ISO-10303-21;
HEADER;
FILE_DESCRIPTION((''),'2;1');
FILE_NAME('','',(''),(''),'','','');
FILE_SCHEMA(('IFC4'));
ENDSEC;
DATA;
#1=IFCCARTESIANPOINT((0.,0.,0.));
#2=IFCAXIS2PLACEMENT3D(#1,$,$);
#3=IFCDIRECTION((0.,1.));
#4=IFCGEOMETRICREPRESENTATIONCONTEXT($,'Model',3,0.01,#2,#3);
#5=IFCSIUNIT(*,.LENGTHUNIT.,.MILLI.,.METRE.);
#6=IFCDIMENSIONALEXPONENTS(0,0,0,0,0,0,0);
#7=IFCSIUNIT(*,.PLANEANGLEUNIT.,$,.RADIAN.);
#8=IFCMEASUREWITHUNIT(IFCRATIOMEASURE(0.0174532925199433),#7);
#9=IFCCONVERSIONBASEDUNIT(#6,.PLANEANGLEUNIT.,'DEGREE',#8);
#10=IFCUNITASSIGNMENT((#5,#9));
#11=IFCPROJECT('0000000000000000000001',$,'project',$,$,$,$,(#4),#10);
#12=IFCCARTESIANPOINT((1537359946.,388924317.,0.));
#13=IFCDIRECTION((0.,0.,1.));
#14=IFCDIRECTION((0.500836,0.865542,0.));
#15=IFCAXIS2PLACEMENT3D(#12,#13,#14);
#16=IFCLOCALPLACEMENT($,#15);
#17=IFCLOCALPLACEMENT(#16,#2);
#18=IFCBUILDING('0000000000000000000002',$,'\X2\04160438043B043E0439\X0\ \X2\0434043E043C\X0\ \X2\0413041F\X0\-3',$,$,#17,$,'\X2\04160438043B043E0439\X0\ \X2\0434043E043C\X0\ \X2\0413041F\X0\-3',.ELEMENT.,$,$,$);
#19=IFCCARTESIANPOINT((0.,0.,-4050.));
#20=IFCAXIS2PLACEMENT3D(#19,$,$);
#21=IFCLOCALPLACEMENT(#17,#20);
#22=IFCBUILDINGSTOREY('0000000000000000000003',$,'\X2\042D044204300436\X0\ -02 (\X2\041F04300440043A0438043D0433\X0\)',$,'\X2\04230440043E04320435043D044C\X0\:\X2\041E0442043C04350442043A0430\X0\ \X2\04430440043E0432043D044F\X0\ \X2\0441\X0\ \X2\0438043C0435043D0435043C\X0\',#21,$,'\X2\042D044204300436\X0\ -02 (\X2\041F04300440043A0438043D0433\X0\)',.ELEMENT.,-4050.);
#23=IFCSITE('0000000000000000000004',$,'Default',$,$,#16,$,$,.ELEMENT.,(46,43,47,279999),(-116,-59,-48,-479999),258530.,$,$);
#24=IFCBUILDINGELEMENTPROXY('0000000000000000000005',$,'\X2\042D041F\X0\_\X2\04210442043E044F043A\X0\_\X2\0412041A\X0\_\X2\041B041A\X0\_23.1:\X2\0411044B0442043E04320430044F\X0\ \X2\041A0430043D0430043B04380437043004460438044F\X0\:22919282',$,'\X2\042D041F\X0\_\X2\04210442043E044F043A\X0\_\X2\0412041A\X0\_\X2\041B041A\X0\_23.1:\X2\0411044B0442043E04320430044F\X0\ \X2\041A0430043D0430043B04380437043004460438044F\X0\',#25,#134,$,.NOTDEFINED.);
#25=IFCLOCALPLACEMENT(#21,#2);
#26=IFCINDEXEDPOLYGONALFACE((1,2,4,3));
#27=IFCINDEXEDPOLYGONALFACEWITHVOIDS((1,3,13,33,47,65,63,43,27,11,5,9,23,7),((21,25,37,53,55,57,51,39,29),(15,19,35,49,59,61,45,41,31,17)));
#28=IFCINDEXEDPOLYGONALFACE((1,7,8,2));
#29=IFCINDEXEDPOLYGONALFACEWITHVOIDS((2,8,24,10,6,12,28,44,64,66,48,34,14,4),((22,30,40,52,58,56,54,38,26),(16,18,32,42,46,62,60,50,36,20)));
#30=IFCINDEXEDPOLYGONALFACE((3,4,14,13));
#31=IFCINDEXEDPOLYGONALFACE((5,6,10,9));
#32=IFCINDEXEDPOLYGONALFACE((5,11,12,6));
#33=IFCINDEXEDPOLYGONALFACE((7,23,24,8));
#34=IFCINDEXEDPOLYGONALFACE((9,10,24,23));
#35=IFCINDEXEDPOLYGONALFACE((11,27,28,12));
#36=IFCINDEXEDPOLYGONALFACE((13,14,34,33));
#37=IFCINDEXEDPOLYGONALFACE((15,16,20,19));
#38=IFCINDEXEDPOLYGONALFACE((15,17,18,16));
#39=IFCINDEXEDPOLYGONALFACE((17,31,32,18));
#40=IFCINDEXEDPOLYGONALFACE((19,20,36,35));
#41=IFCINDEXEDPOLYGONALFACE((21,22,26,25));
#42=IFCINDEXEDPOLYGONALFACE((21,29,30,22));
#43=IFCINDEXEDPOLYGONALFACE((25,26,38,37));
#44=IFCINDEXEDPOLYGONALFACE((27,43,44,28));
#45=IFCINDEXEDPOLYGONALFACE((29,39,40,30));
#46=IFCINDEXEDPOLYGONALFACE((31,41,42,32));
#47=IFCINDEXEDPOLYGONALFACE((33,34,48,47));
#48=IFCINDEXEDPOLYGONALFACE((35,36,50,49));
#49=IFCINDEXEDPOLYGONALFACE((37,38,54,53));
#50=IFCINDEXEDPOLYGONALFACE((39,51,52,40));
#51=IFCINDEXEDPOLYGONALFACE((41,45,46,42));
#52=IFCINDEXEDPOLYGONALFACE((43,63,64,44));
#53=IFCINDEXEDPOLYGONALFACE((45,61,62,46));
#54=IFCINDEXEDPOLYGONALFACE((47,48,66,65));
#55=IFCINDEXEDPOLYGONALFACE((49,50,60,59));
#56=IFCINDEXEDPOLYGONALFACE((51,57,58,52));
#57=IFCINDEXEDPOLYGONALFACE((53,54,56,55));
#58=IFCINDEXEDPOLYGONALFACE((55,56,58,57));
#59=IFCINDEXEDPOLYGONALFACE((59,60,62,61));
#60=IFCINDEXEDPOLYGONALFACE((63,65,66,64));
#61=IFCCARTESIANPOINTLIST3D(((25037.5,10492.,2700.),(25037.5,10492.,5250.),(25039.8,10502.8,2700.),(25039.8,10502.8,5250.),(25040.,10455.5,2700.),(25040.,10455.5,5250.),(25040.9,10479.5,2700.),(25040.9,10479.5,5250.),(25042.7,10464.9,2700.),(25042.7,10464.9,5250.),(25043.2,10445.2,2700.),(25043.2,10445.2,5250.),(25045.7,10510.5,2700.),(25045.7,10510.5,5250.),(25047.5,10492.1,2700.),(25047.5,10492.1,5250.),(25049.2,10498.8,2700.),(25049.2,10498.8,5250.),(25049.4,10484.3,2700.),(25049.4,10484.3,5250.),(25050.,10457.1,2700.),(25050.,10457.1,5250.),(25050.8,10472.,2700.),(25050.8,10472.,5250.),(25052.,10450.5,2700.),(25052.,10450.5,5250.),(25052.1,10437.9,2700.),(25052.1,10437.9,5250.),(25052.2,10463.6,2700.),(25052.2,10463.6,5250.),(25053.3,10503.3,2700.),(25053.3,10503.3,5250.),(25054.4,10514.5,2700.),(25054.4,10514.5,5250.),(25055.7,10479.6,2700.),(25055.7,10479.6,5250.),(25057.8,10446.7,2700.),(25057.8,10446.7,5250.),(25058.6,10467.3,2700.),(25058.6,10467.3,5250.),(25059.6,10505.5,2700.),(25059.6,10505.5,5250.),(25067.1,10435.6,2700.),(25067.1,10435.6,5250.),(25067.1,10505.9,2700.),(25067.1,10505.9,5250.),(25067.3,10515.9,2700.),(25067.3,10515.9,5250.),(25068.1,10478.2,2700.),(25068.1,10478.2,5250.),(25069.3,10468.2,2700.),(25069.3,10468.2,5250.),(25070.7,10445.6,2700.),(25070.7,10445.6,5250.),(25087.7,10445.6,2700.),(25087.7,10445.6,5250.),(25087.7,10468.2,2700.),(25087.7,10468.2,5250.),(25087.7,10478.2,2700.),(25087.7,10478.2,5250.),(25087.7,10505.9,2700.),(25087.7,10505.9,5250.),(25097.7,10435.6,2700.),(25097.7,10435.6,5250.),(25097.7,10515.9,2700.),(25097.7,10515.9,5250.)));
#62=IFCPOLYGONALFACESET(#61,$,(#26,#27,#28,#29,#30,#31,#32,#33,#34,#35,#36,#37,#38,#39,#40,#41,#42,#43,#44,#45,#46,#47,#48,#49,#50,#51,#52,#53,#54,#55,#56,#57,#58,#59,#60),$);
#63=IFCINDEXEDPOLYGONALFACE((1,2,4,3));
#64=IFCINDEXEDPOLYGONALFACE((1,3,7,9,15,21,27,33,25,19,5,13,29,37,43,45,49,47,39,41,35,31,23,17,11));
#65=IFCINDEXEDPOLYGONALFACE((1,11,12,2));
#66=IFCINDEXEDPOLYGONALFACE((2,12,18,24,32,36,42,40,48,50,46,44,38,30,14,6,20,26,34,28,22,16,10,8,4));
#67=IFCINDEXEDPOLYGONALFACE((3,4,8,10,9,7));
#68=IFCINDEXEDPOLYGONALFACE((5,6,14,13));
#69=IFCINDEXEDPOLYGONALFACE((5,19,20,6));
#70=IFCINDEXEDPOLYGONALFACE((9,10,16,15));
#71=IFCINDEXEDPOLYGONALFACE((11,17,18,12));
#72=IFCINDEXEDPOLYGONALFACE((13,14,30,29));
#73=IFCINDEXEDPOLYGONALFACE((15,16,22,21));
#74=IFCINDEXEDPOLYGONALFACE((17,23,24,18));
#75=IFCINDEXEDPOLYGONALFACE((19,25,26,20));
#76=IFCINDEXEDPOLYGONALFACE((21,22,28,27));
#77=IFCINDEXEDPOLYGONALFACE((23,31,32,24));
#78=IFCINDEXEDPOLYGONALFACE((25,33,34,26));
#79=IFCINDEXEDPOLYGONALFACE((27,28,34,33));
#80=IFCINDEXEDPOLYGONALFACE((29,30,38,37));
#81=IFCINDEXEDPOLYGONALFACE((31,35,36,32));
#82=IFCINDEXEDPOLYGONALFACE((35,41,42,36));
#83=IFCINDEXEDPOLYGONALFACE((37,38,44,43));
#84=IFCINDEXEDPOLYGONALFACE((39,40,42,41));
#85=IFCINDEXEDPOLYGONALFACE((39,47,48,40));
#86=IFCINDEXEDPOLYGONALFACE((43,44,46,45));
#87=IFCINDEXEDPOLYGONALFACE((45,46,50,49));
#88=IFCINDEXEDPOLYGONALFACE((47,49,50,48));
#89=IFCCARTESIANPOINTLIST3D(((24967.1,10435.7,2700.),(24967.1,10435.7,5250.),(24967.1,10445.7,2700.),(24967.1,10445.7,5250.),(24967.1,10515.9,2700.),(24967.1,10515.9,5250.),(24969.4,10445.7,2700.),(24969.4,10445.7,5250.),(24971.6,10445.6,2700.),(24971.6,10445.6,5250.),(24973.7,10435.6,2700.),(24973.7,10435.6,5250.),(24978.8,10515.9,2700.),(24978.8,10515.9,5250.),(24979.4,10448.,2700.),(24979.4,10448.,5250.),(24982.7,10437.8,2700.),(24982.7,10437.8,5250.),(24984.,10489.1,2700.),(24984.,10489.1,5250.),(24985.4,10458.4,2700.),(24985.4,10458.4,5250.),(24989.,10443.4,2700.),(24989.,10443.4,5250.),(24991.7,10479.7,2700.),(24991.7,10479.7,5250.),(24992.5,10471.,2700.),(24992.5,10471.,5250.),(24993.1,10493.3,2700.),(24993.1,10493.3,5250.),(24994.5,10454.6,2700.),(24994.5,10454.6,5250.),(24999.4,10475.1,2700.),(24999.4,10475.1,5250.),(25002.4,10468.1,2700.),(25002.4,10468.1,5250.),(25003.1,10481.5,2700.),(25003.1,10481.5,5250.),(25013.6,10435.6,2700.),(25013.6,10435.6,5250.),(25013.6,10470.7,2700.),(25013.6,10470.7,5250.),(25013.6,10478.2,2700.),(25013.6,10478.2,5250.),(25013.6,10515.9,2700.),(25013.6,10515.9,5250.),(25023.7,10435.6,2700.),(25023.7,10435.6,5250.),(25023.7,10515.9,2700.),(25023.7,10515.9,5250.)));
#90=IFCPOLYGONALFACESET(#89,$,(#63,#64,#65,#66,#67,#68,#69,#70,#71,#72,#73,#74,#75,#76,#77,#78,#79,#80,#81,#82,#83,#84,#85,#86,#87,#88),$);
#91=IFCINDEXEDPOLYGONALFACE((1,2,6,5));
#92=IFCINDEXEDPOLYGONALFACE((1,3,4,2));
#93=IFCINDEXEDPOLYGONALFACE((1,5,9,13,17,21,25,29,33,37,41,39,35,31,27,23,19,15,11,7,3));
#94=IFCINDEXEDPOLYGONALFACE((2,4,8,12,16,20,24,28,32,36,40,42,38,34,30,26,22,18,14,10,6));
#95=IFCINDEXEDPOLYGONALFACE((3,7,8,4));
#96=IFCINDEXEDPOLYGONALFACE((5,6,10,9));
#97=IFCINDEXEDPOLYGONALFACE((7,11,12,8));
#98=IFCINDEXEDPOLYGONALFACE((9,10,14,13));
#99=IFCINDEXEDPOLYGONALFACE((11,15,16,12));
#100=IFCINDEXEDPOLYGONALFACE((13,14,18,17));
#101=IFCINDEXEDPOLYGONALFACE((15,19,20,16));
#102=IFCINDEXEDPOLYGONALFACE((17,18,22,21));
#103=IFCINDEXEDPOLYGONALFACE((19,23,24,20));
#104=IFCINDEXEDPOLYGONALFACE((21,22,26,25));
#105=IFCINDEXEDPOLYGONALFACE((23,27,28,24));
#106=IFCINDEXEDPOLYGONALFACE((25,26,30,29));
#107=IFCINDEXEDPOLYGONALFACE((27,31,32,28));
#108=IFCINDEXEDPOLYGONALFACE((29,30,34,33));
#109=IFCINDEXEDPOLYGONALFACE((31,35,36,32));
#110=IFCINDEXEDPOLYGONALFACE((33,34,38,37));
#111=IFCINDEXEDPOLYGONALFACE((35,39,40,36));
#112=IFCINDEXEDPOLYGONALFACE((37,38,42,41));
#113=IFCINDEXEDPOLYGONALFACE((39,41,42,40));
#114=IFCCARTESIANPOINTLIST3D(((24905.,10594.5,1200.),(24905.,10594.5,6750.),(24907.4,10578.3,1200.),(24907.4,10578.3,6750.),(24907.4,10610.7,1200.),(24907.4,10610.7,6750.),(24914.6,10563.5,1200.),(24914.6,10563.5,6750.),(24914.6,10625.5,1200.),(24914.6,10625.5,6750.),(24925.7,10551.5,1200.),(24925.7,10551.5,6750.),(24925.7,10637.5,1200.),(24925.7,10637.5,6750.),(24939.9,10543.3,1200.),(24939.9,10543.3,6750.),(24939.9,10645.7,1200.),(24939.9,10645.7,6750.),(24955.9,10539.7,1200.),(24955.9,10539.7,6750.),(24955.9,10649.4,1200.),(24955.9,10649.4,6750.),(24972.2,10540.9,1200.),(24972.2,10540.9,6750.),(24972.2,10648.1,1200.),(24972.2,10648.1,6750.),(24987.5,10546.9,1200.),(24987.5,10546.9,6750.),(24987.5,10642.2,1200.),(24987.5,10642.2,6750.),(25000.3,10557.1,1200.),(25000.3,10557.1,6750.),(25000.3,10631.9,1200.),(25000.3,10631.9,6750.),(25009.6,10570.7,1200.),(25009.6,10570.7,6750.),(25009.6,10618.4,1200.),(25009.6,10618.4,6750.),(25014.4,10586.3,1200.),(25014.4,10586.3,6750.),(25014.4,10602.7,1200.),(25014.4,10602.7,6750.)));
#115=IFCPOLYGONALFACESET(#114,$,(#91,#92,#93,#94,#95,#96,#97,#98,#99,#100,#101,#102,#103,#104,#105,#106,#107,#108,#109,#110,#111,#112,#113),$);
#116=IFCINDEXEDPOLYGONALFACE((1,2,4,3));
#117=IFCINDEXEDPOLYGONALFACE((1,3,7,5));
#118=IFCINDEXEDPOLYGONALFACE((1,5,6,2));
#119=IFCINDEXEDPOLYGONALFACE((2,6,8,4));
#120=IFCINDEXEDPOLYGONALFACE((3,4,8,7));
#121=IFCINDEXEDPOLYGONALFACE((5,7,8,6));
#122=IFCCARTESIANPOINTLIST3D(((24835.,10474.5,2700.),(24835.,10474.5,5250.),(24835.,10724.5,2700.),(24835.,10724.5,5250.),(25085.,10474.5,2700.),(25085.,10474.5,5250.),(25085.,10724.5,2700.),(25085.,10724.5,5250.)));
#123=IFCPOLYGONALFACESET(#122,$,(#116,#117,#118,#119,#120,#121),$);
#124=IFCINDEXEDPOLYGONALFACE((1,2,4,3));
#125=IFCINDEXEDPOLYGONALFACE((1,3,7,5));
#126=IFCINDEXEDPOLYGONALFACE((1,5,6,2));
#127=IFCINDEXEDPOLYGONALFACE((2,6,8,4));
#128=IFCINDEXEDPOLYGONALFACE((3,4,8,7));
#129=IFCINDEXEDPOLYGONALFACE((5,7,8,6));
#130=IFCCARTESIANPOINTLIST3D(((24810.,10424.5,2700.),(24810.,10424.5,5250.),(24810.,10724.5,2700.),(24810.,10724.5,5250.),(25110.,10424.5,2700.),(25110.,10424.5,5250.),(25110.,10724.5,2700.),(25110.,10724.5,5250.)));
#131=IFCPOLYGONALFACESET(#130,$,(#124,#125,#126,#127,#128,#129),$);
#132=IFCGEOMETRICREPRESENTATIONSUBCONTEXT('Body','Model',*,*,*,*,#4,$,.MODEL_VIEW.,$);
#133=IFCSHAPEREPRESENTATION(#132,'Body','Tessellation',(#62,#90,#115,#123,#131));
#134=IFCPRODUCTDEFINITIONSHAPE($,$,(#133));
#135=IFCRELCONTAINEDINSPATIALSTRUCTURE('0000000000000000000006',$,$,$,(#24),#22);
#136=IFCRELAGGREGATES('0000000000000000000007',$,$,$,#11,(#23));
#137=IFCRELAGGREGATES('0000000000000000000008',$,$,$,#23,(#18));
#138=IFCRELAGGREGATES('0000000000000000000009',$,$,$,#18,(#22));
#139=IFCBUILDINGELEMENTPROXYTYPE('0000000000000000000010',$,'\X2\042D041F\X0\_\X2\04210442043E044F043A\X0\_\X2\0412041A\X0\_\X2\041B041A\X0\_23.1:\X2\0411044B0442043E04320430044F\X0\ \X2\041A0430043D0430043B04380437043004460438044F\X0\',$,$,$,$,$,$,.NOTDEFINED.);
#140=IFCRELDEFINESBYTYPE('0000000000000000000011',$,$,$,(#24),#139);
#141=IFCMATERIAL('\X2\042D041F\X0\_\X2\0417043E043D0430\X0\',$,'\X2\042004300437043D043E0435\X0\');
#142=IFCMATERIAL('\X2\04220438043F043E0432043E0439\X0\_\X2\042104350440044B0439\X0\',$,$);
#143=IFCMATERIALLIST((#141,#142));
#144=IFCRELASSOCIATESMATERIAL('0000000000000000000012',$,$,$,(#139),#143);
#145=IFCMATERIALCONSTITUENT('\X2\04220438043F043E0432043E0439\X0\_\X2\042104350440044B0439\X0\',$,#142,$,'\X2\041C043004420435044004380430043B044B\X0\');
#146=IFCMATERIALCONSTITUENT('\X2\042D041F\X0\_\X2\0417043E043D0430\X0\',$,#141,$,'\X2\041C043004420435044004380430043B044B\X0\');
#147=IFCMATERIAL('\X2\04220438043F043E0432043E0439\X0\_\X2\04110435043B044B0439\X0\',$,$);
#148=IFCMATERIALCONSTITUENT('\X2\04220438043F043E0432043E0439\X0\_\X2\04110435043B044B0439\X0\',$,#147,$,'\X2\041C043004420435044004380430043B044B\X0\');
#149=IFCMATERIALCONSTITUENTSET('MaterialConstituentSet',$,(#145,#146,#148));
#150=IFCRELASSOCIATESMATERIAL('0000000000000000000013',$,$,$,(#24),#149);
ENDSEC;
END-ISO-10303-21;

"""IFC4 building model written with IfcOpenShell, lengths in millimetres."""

from ifc_helpers import new_model, entity, si_unit, converted_unit, direction, frame, frame_2d, origin, place, context, subcontext, project, spatial, polyline, rectangle, circle, outline, extrude, source, transform, mapped, material, material_list, constituent, constituent_set, type_object, type_shapes, element, save


model = new_model("IFC4")

# Units and contexts
model_context = context("Model", 3, precision=0.01, world=origin(), true_north=direction((0.0, 1.0)))
body_context = subcontext(model_context, "Body", "Model", "MODEL_VIEW")
ifc_project = project(units=[si_unit("LENGTHUNIT", "METRE", prefix="MILLI"), converted_unit("PLANEANGLEUNIT", "DEGREE", entity("IfcRatioMeasure", 0.0174532925199433), si_unit("PLANEANGLEUNIT", "RADIAN"), dimensions=[0, 0, 0, 0, 0, 0, 0])], contexts=[model_context])

# Site, building, storey
site_placement = place(None, frame((1537359946.0, 388924317.0, 0.0), z_axis=(0.0, 0.0, 1.0), x_axis=(0.500836, 0.865542, 0.0)))
site = spatial("IfcSite", under=ifc_project, at=site_placement, Name="Default", CompositionType="ELEMENT", RefLatitude=(46, 43, 47, 279999), RefLongitude=(-116, -59, -48, -479999), RefElevation=258530.0)
building_placement = place(site_placement, origin())
building = spatial("IfcBuilding", under=site, at=building_placement, Name="Жилой дом ГП-3", LongName="Жилой дом ГП-3", CompositionType="ELEMENT")
storey_placement = place(building_placement, frame((0.0, 0.0, -4050.0)))
storey = spatial("IfcBuildingStorey", under=building, at=storey_placement, Name="Этаж -02 (Паркинг)", ObjectType="Уровень:Отметка уровня с именем", LongName="Этаж -02 (Паркинг)", CompositionType="ELEMENT", Elevation=-4050.0)

# Shared definitions
ifc_material_1 = material(Name="ЭП_Зона", Category="Разное")
ifc_material_2 = material(Name="Типовой_Белый")
ifc_material_3 = material(Name="Типовой_Серый")

# Building element proxy
ifc_material_list_1 = material_list([ifc_material_1, ifc_material_3])
building_element_proxy_type_1 = type_object("IfcBuildingElementProxyType", Name="ЭП_Стояк_ВК_ЛК_23.1:Бытовая Канализация", PredefinedType="NOTDEFINED", material=ifc_material_list_1)
shared_shape_1 = source(origin(), body_context, "Body", "SweptSolid", [
    extrude(outline(polyline([(-42.2, -39.0), (-11.8, -39.0), (1.1, -37.6), (9.8, -33.5), (15.7, -25.8), (18.0, -15.0), (14.6, -2.5), (4.7, 5.0), (12.8, 12.1), (15.5, 21.5), (12.3, 31.8), (3.4, 39.0), (-11.6, 41.4), (-42.2, 41.4), (-42.2, -39.0)]), holes=[polyline([(-32.2, 8.8), (-32.2, 31.4), (-15.2, 31.4), (-2.3, 30.3), (3.5, 26.4), (5.5, 19.9), (3.3, 13.3), (-3.1, 9.6), (-13.9, 8.8), (-32.2, 8.8)]), polyline([(-32.2, -28.9), (-32.2, -1.3), (-12.6, -1.3), (-0.2, -2.6), (6.1, -7.3), (8.0, -15.1), (6.3, -21.9), (2.2, -26.3), (-4.1, -28.5), (-11.6, -28.9), (-32.2, -28.9)])]), frame((54.5, -52.4, -1350.0)), (0.0, 0.0, 1.0), 2550.0),
    extrude(outline(polyline([(-32.1, -31.9), (48.3, -31.9), (48.3, -21.8), (10.6, -21.8), (13.8, -11.4), (25.6, -1.3), (48.3, 13.0), (48.3, 24.6), (21.4, 7.7), (12.0, 0.1), (7.4, -7.7), (3.3, -0.7), (-9.3, 6.4), (-19.7, 12.3), (-22.1, 20.2), (-22.0, 22.4), (-22.0, 24.6), (-32.0, 24.6), (-32.1, 18.0), (-29.9, 9.0), (-24.3, 2.8), (-13.1, -2.8), (0.4, -10.6), (3.0, -21.8), (-32.1, -21.8), (-32.1, -31.9)])), frame((118.2, -43.1, -1350.0), z_axis=(0.0, 0.0, 1.0), x_axis=(0.0, -1.0, 0.0)), (0.0, 0.0, 1.0), 2550.0),
    extrude(circle(Radius=55.0, at=frame_2d((0.0, 0.0), x_axis=(1.0, 0.0))), frame((150.0, -170.0, -2850.0)), (0.0, 0.0, 1.0), 5550.0),
    extrude(rectangle(XDim=250.0, YDim=250.0, at=frame_2d((0.0, 0.0), x_axis=(1.0, 0.0))), frame((150.0, -175.0, -1350.0)), (0.0, 0.0, 1.0), 2550.0),
    extrude(rectangle(XDim=300.0, YDim=300.0, at=frame_2d((0.0, 0.0), x_axis=(1.0, 0.0))), frame((150.0, -150.0, -1350.0)), (0.0, 0.0, 1.0), 2550.0),
])
type_shapes(building_element_proxy_type_1, [shared_shape_1])
ifc_constituent_1 = constituent(ifc_material_3, Name="Типовой_Серый", Category="Материалы")
ifc_constituent_2 = constituent(ifc_material_1, Name="ЭП_Зона", Category="Материалы")
ifc_constituent_3 = constituent(ifc_material_2, Name="Типовой_Белый", Category="Материалы")
ifc_constituent_set_1 = constituent_set(constituents=[ifc_constituent_1, ifc_constituent_2, ifc_constituent_3], Name="MaterialConstituentSet")
proxy_1_placement = place(storey_placement, frame((25110.0, 10424.5, 4050.0), z_axis=(0.0, 0.0, 1.0), x_axis=(-1.0, 0.0, 0.0)))
element("IfcBuildingElementProxy", 1, at=proxy_1_placement, inside=storey, type_object=building_element_proxy_type_1, material=ifc_constituent_set_1, Name="ЭП_Стояк_ВК_ЛК_23.1:Бытовая Канализация:22919282", ObjectType="ЭП_Стояк_ВК_ЛК_23.1:Бытовая Канализация", PredefinedType="NOTDEFINED", context=body_context, shape_type="MappedRepresentation", body=[
    mapped(shared_shape_1, transform((0.0, 0.0, 0.0), scale=1.0)),
])

save(model, "model.ifc")
